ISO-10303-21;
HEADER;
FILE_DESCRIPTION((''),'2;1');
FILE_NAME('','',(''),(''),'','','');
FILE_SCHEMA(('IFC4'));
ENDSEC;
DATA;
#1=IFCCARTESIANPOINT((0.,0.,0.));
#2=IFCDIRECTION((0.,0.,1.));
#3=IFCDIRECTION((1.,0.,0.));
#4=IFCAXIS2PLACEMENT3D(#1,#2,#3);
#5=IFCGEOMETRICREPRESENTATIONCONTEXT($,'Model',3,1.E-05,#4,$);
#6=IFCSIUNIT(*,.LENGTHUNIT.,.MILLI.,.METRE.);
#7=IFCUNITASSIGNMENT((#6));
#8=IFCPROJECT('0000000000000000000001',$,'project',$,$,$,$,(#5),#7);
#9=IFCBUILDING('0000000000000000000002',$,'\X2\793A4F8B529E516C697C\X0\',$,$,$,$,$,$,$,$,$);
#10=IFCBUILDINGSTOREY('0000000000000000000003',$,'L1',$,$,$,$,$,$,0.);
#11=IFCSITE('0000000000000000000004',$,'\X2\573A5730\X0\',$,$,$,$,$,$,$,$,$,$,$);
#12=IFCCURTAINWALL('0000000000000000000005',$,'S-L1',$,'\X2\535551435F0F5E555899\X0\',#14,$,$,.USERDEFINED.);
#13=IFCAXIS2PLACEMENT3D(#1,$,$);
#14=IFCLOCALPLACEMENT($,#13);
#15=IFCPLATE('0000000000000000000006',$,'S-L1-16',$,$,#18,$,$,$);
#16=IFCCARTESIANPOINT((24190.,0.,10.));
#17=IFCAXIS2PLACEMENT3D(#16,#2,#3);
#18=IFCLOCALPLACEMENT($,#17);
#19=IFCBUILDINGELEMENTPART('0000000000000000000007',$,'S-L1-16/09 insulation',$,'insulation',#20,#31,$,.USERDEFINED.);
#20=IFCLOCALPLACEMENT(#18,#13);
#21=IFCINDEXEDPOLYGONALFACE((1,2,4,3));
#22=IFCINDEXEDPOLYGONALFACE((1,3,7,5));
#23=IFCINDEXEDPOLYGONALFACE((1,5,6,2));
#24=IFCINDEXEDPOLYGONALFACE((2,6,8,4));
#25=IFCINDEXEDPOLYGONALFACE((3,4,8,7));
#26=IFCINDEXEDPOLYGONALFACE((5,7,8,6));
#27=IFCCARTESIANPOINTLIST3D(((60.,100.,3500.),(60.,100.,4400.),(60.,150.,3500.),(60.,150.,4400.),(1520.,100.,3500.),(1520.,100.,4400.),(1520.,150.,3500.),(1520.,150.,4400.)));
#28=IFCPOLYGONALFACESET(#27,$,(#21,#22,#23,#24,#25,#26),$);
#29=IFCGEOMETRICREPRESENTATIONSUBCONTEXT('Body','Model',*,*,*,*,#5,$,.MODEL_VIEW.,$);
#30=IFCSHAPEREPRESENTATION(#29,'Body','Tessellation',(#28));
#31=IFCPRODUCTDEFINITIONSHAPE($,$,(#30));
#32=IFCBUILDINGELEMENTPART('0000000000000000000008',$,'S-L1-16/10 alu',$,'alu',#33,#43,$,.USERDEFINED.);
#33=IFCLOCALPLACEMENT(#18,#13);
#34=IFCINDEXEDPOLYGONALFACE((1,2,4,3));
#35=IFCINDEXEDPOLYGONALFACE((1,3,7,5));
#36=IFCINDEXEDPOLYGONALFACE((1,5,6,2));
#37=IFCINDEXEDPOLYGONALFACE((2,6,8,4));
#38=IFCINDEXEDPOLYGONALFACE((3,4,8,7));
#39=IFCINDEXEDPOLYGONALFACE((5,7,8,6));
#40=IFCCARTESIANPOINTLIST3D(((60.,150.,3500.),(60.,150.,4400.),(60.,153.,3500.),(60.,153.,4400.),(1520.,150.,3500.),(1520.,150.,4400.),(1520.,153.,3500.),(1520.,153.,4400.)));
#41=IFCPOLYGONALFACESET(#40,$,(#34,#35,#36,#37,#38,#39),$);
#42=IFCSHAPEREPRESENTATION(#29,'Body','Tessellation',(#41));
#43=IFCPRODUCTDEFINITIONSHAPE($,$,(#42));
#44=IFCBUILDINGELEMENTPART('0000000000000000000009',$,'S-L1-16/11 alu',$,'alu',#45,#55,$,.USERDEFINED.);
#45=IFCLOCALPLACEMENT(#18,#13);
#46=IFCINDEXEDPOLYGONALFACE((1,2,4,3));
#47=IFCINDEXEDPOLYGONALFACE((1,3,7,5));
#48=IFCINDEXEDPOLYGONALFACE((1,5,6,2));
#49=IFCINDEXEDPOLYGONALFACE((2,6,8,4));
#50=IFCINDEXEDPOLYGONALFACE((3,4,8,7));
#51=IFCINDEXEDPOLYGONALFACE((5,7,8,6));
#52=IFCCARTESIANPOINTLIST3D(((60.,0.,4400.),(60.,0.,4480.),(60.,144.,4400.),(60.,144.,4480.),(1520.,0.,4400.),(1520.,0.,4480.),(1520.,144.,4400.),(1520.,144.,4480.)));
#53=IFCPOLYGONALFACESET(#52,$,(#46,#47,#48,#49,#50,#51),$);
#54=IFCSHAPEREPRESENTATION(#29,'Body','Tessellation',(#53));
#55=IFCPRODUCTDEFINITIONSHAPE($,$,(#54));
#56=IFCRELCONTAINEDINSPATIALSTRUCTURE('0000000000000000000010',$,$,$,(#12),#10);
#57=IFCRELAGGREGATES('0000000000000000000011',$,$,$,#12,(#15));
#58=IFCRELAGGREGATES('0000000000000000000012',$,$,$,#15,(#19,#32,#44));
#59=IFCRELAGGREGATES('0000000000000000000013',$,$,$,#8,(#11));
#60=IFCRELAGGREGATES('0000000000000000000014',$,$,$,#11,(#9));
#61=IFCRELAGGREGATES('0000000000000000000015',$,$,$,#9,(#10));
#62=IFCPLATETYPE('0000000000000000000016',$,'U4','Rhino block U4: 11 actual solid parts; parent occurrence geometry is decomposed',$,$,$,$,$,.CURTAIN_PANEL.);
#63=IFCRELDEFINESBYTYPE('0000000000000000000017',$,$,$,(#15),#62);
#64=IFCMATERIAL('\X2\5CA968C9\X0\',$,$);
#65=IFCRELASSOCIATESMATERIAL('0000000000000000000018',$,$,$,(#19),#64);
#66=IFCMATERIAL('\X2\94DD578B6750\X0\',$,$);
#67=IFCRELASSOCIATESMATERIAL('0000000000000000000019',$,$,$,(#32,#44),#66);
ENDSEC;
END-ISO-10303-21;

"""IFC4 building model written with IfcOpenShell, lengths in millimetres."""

from ifc_helpers import new_model, si_unit, frame, frame_2d, origin, origin_with_axes, place, context, subcontext, project, spatial, rectangle, extrude, source, transform, mapped, material, type_object, element, aggregate, save


model = new_model("IFC4")

# Units and contexts
model_context = context("Model", 3, precision=1e-05, world=origin_with_axes())
body_context = subcontext(model_context, "Body", "Model", "MODEL_VIEW")
ifc_project = project(units=[si_unit("LENGTHUNIT", "METRE", prefix="MILLI")], contexts=[model_context])

# Site, building, storey
site = spatial("IfcSite", under=ifc_project, Name="场地")
building = spatial("IfcBuilding", under=site, Name="示例办公楼")
storey = spatial("IfcBuildingStorey", under=building, Name="L1", Elevation=0.0)

# Curtain wall, plate, building element parts
curtain_wall = element("IfcCurtainWall", 1, inside=storey, Name="S-L1", ObjectType="单元式幕墙", PredefinedType="USERDEFINED")
ifc_material_1 = material(Name="铝型材")
ifc_material_2 = material(Name="岩棉")
plate_type_1 = type_object("IfcPlateType", Name="U4", Description="Rhino block U4: 11 actual solid parts; parent occurrence geometry is decomposed", PredefinedType="CURTAIN_PANEL")
plate_1_placement = place(None, frame((24190.0, 0.0, 10.0), z_axis=(0.0, 0.0, 1.0), x_axis=(1.0, 0.0, 0.0)))
plate_1 = element("IfcPlate", 2, at=plate_1_placement, type_object=plate_type_1, Name="S-L1-16")
aggregate(curtain_wall, [plate_1])
shared_shape_1 = source(origin(), body_context, "Body", "SweptSolid", [
    extrude(rectangle(XDim=1460.0, YDim=50.0, at=frame_2d((790.0, 125.0))), frame((0.0, 0.0, 3500.0)), (0.0, 0.0, 1.0), 900.0),
])
building_element_part_1_placement = place(plate_1_placement, origin())
building_element_part_1 = element("IfcBuildingElementPart", 3, at=building_element_part_1_placement, material=ifc_material_2, Name="S-L1-16/09 insulation", ObjectType="insulation", PredefinedType="USERDEFINED", context=body_context, shape_type="MappedRepresentation", body=[
    mapped(shared_shape_1, transform((0.0, 0.0, 0.0))),
])
shared_shape_2 = source(origin(), body_context, "Body", "SweptSolid", [
    extrude(rectangle(XDim=1460.0, YDim=3.0, at=frame_2d((790.0, 151.5))), frame((0.0, 0.0, 3500.0)), (0.0, 0.0, 1.0), 900.0),
])
building_element_part_2_placement = place(plate_1_placement, origin())
building_element_part_2 = element("IfcBuildingElementPart", 4, at=building_element_part_2_placement, material=ifc_material_1, Name="S-L1-16/10 alu", ObjectType="alu", PredefinedType="USERDEFINED", context=body_context, shape_type="MappedRepresentation", body=[
    mapped(shared_shape_2, transform((0.0, 0.0, 0.0))),
])
shared_shape_3 = source(origin(), body_context, "Body", "SweptSolid", [
    extrude(rectangle(XDim=1460.0, YDim=144.0, at=frame_2d((790.0, 72.0))), frame((0.0, 0.0, 4400.0)), (0.0, 0.0, 1.0), 80.0),
])
building_element_part_3_placement = place(plate_1_placement, origin())
building_element_part_3 = element("IfcBuildingElementPart", 5, at=building_element_part_3_placement, material=ifc_material_1, Name="S-L1-16/11 alu", ObjectType="alu", PredefinedType="USERDEFINED", context=body_context, shape_type="MappedRepresentation", body=[
    mapped(shared_shape_3, transform((0.0, 0.0, 0.0))),
])
aggregate(plate_1, [building_element_part_1, building_element_part_2, building_element_part_3])

save(model, "model.ifc")
